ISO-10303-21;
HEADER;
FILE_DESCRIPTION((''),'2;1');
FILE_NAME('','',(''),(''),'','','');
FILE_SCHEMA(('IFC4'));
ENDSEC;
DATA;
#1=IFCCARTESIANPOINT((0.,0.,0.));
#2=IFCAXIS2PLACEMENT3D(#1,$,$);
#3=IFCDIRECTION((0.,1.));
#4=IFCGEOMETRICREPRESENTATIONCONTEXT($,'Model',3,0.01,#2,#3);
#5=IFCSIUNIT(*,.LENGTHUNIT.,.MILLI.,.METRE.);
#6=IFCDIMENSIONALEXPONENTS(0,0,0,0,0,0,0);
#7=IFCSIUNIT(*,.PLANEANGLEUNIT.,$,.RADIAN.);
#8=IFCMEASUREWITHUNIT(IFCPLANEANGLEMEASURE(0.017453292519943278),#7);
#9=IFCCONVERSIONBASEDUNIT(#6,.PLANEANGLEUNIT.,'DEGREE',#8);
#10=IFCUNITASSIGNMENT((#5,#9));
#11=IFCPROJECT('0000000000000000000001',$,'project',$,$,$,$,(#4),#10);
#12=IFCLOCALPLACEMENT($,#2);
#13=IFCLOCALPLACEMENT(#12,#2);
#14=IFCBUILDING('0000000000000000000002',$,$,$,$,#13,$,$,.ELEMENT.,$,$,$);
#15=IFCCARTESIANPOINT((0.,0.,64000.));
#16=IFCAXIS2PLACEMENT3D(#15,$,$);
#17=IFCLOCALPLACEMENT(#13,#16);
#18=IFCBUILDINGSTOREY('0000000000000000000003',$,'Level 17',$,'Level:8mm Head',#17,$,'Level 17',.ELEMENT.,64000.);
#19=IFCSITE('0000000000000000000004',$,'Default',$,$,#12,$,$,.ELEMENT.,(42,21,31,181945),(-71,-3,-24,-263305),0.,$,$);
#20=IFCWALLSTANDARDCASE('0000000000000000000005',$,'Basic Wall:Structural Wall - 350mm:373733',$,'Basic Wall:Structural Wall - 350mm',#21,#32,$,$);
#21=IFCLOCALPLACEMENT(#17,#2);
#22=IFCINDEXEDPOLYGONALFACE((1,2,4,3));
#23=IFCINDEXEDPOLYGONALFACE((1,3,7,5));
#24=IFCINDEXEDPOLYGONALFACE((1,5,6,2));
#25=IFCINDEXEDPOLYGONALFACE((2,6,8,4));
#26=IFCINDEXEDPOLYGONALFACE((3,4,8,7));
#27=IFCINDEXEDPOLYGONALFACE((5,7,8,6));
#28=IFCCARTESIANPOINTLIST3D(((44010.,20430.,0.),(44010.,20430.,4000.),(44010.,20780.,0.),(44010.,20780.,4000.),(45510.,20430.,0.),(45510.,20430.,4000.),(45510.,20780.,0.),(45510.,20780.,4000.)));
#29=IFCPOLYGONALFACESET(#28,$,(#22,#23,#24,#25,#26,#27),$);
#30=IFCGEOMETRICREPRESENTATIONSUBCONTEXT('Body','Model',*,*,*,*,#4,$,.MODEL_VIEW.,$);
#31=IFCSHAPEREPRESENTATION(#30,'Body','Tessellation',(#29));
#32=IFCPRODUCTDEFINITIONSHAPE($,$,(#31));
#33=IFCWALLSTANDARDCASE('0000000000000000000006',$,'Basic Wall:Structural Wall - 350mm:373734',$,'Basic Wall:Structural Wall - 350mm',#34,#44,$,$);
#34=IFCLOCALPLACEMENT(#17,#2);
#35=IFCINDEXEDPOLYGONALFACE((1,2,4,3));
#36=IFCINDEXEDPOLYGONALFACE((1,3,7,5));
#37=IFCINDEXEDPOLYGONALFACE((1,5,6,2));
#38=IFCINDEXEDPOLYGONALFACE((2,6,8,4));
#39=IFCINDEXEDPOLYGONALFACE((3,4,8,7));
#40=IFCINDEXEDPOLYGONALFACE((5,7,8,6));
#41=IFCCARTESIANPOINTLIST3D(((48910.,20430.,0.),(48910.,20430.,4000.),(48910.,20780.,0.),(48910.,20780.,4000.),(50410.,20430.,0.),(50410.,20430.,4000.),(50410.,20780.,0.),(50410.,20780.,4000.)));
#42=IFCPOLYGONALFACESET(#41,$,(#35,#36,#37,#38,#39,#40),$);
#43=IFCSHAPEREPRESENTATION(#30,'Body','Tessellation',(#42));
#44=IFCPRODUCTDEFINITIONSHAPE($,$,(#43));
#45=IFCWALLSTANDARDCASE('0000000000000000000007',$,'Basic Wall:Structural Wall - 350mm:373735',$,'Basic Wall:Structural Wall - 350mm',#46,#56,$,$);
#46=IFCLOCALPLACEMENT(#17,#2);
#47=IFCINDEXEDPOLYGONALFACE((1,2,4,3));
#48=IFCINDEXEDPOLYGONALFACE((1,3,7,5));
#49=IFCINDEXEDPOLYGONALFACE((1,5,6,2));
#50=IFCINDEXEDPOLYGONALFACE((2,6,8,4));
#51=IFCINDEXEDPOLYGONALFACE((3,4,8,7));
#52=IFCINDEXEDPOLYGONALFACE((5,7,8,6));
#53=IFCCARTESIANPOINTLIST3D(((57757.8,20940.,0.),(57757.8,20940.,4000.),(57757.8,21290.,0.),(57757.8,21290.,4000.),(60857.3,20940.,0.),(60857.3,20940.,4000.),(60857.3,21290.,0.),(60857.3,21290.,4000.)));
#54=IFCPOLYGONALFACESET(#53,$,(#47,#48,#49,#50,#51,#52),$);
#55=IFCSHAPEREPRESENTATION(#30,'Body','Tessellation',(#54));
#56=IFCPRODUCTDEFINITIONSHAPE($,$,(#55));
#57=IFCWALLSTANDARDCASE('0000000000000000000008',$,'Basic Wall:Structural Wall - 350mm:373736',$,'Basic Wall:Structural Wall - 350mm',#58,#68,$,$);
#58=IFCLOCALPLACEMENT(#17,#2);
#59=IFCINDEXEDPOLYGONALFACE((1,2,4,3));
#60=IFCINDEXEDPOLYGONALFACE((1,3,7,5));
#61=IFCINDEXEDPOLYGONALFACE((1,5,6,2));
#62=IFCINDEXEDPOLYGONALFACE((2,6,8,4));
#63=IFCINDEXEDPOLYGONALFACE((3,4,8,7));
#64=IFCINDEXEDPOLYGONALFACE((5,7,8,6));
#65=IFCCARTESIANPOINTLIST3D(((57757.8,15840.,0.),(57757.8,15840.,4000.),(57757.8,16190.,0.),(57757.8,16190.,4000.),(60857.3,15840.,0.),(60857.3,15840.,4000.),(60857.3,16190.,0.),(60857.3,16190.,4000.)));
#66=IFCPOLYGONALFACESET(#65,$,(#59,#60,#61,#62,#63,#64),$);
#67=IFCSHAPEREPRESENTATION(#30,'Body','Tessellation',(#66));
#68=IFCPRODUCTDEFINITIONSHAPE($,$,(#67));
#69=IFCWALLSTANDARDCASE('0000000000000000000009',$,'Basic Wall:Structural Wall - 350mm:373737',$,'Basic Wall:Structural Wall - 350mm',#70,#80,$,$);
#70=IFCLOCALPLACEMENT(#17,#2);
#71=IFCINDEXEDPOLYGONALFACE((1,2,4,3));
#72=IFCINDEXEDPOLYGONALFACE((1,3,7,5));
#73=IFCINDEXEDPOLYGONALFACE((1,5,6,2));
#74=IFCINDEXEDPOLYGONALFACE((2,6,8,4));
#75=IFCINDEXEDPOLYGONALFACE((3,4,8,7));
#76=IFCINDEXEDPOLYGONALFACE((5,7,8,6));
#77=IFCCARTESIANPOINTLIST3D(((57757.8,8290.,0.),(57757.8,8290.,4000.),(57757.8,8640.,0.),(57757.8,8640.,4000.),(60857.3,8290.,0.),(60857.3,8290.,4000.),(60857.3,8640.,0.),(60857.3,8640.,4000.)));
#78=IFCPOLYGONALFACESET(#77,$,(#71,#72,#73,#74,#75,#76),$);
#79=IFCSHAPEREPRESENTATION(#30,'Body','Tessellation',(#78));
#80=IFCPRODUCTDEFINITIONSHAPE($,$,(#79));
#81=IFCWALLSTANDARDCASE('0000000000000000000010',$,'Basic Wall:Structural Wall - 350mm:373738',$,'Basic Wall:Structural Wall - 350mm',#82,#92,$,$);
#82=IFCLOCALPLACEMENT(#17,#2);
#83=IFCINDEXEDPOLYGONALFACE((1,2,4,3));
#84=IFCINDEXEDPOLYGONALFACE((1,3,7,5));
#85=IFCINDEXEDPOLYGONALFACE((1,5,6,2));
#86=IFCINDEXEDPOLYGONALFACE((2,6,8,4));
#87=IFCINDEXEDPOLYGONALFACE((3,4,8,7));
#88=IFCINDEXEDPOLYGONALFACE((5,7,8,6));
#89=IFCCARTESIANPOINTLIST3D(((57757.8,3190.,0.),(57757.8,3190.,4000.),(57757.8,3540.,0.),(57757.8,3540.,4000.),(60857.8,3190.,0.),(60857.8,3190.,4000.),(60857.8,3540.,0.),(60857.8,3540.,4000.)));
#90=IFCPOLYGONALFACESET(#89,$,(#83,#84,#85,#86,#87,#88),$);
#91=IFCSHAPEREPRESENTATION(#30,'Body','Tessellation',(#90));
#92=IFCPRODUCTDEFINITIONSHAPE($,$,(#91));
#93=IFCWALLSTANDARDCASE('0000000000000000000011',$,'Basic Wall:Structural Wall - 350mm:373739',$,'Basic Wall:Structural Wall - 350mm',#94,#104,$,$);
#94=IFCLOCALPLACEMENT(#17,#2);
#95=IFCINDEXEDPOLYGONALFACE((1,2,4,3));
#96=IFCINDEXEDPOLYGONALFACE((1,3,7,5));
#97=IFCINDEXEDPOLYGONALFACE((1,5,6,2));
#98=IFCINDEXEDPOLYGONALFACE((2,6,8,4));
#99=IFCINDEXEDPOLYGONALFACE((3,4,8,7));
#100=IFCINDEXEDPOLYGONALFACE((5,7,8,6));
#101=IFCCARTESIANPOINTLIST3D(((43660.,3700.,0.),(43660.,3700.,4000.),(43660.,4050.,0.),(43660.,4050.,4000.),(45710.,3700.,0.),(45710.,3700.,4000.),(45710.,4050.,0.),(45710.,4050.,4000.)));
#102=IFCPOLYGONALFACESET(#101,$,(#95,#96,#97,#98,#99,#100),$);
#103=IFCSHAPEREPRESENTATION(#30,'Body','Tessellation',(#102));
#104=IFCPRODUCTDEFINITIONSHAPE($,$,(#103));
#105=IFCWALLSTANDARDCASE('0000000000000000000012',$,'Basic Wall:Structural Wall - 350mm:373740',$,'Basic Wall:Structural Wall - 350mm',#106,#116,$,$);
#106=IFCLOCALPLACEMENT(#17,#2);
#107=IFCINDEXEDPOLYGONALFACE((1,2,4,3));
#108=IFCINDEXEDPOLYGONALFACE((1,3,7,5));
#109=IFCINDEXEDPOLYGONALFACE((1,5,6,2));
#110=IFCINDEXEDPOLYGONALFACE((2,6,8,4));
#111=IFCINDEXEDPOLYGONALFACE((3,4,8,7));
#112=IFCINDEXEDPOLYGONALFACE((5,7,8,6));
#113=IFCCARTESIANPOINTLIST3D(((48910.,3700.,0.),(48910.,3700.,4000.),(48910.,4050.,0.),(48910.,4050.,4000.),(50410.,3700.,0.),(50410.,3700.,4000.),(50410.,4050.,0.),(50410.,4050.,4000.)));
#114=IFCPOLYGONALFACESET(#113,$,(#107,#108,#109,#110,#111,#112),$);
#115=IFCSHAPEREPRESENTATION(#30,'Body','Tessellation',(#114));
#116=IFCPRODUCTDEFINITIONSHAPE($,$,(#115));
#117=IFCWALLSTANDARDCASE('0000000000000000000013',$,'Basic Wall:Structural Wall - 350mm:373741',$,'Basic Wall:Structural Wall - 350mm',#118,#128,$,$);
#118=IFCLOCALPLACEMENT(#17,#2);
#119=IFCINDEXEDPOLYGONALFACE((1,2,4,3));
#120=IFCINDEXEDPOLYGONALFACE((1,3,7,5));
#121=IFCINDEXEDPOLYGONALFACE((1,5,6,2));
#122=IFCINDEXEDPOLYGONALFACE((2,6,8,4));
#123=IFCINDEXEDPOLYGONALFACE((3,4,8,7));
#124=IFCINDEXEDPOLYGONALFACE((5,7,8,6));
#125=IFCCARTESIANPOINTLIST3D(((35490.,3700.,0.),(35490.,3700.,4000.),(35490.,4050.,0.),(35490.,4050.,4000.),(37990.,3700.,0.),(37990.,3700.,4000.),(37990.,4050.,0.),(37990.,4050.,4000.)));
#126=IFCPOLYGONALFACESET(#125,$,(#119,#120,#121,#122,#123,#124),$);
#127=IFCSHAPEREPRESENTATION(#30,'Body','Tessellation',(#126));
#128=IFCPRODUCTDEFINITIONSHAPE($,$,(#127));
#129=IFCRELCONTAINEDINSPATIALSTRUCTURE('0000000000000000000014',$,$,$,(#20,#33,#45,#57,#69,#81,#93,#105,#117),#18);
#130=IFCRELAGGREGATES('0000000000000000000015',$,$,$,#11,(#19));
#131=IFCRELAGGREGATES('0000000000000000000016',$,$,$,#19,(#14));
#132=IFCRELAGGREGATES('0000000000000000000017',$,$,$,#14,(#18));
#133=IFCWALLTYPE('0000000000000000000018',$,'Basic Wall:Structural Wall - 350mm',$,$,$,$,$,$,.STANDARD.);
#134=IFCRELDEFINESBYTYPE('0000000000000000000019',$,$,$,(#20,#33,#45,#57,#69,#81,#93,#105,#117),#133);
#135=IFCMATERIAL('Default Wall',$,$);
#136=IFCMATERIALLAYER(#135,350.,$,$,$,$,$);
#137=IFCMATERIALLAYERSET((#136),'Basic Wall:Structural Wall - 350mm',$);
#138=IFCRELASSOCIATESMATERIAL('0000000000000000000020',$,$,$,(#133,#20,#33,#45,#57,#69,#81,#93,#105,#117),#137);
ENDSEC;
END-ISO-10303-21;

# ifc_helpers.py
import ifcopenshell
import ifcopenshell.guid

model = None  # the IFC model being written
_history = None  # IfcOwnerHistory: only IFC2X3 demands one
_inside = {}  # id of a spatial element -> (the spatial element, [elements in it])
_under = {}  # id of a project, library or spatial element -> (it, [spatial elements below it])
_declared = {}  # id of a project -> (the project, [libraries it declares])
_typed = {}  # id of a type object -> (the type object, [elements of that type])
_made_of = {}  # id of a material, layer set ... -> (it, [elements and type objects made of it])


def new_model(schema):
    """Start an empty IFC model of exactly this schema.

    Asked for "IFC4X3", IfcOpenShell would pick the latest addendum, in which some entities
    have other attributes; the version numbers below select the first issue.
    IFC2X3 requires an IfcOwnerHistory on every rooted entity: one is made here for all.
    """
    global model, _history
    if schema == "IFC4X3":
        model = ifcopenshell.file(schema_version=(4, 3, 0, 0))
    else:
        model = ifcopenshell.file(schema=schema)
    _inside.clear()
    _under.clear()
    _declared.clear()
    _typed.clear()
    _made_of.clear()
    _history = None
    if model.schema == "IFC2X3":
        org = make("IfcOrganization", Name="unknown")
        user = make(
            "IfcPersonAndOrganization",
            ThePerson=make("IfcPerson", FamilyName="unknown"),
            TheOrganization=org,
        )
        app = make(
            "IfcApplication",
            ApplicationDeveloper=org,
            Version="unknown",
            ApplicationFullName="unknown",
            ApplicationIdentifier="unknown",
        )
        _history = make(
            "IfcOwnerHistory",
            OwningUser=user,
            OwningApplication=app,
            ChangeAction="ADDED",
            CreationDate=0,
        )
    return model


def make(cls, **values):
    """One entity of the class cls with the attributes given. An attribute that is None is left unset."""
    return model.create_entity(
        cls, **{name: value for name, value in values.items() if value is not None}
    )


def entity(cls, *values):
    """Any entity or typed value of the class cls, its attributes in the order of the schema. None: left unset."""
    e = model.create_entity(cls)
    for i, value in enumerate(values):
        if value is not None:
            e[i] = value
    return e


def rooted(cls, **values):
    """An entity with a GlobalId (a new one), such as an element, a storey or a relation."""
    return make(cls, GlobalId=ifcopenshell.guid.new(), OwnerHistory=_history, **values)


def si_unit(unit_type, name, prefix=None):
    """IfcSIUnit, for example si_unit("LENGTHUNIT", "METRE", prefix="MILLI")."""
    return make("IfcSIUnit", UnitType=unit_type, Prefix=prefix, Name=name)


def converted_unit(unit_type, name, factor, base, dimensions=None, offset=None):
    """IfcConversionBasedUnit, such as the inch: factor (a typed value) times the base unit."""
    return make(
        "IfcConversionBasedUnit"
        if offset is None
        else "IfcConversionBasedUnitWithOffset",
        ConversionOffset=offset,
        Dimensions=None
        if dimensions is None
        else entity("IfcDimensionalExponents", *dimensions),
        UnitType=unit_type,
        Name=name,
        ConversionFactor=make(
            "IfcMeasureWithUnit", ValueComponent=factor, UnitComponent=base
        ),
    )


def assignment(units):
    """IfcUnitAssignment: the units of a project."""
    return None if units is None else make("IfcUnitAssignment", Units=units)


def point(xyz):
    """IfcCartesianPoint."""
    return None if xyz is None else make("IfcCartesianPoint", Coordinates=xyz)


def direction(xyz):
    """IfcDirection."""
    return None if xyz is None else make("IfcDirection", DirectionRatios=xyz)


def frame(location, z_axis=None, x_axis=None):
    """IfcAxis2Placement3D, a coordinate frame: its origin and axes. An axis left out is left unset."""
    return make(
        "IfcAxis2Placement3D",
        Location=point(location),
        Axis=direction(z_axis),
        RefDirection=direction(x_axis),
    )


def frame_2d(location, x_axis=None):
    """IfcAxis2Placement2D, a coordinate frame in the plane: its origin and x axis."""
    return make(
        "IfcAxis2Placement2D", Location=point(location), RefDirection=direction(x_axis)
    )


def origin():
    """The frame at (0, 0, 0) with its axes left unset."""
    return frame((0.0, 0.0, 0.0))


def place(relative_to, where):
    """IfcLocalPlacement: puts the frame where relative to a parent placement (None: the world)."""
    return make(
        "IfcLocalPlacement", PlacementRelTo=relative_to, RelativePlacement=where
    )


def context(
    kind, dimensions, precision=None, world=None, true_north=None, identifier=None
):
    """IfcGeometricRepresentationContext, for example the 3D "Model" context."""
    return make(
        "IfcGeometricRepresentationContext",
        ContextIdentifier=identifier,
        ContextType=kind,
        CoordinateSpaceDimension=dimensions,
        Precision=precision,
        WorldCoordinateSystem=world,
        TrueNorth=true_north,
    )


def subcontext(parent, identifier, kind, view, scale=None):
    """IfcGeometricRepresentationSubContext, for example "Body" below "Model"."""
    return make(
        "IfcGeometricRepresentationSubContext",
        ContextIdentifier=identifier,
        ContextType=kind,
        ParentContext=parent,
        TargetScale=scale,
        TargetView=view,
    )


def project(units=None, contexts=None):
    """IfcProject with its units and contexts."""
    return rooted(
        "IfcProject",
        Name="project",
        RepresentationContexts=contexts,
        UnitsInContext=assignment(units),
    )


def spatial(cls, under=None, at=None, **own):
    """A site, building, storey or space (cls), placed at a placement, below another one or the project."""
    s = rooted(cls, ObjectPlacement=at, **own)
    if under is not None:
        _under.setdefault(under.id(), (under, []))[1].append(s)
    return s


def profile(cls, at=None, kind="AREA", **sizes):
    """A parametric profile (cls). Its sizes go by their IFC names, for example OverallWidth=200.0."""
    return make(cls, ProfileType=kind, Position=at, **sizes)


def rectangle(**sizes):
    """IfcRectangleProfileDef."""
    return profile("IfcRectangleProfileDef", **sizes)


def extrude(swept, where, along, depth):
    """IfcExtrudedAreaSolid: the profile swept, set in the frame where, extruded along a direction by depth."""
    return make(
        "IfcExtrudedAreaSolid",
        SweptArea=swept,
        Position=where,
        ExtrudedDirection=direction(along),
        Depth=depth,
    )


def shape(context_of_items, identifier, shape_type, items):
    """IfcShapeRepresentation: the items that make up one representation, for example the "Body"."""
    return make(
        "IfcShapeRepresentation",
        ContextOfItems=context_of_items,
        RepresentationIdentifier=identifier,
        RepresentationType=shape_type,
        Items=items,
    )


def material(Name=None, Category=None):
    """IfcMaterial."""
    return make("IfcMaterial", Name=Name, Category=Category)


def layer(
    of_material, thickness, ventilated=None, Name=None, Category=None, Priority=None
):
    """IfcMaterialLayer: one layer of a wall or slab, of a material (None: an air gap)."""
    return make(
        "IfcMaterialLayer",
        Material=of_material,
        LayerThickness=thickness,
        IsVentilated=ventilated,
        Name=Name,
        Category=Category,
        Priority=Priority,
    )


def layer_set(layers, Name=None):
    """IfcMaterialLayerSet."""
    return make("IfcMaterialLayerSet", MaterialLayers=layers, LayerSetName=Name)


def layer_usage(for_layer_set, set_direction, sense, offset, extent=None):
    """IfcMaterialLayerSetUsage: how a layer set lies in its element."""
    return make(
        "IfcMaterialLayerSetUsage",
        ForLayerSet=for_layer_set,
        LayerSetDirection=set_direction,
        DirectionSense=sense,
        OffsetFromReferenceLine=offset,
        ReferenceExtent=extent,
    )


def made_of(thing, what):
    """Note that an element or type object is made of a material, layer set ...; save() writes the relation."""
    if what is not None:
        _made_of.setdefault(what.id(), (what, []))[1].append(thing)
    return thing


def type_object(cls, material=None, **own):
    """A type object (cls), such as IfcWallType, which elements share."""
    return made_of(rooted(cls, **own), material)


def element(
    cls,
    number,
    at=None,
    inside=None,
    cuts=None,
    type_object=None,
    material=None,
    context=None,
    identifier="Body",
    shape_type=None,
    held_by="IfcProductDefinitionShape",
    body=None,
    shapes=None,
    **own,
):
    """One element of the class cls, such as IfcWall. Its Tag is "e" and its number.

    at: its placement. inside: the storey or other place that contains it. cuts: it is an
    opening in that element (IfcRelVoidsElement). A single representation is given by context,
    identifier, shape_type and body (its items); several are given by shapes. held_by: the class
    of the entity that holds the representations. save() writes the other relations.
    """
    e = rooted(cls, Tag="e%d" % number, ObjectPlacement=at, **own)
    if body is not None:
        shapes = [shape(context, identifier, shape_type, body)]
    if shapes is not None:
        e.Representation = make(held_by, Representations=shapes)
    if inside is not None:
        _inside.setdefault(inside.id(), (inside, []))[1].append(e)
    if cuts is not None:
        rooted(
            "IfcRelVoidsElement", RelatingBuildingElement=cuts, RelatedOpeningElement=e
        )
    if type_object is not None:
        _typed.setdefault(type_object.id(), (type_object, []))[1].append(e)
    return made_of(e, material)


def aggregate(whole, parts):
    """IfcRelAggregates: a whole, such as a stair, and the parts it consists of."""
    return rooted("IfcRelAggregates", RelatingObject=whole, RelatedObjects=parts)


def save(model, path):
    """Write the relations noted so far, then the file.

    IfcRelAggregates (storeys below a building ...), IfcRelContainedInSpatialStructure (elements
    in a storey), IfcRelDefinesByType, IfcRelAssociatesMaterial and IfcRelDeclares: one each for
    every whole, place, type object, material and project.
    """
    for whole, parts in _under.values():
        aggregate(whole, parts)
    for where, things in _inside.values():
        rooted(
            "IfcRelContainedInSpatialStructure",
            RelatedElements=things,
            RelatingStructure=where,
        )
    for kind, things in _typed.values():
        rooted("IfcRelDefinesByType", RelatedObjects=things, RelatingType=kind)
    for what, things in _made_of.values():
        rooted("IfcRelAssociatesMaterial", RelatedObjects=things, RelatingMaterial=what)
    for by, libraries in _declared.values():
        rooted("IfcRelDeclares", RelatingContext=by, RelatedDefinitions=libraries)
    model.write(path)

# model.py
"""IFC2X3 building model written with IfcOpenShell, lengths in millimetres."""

from ifc_helpers import new_model, entity, si_unit, converted_unit, direction, frame, frame_2d, origin, place, context, subcontext, project, spatial, rectangle, extrude, material, layer, layer_set, layer_usage, type_object, element, save


model = new_model("IFC2X3")

# Units and contexts
model_context = context("Model", 3, precision=0.01, world=origin(), true_north=direction((0.0, 1.0)))
body_context = subcontext(model_context, "Body", "Model", "MODEL_VIEW")
ifc_project = project(units=[si_unit("LENGTHUNIT", "METRE", prefix="MILLI"), converted_unit("PLANEANGLEUNIT", "DEGREE", entity("IfcPlaneAngleMeasure", 0.017453292519943278), si_unit("PLANEANGLEUNIT", "RADIAN"), dimensions=[0, 0, 0, 0, 0, 0, 0])], contexts=[model_context])

# Site, building, storey
site_placement = place(None, origin())
site = spatial("IfcSite", under=ifc_project, at=site_placement, Name="Default", CompositionType="ELEMENT", RefLatitude=(42, 21, 31, 181945), RefLongitude=(-71, -3, -24, -263305), RefElevation=0.0)
building_placement = place(site_placement, origin())
building = spatial("IfcBuilding", under=site, at=building_placement, CompositionType="ELEMENT")
storey_placement = place(building_placement, frame((0.0, 0.0, 64000.0)))
storey = spatial("IfcBuildingStorey", under=building, at=storey_placement, Name="Level 17", ObjectType="Level:8mm Head", LongName="Level 17", CompositionType="ELEMENT", Elevation=64000.0)

# Walls
ifc_material_1 = material(Name="Default Wall")
ifc_layer_1 = layer(ifc_material_1, 350.0)
ifc_layer_set_1 = layer_set([ifc_layer_1], Name="Basic Wall:Structural Wall - 350mm")
wall_type_1 = type_object("IfcWallType", Name="Basic Wall:Structural Wall - 350mm", PredefinedType="STANDARD", material=ifc_layer_set_1)
ifc_layer_usage_1 = layer_usage(ifc_layer_set_1, "AXIS2", "NEGATIVE", 175.0)
wall_1_placement = place(storey_placement, frame((44010.0, 20605.0, 0.0)))
element("IfcWallStandardCase", 1, at=wall_1_placement, inside=storey, type_object=wall_type_1, material=ifc_layer_usage_1, Name="Basic Wall:Structural Wall - 350mm:373733", ObjectType="Basic Wall:Structural Wall - 350mm", context=body_context, shape_type="SweptSolid", body=[
    extrude(rectangle(XDim=1500.0, YDim=350.0, at=frame_2d((750.0, 0.0), x_axis=(-1.0, 0.0))), origin(), (0.0, 0.0, 1.0), 4000.0),
])
ifc_layer_usage_2 = layer_usage(ifc_layer_set_1, "AXIS2", "NEGATIVE", 175.0)
wall_2_placement = place(storey_placement, frame((48910.0, 20605.0, 0.0)))
element("IfcWallStandardCase", 2, at=wall_2_placement, inside=storey, type_object=wall_type_1, material=ifc_layer_usage_2, Name="Basic Wall:Structural Wall - 350mm:373734", ObjectType="Basic Wall:Structural Wall - 350mm", context=body_context, shape_type="SweptSolid", body=[
    extrude(rectangle(XDim=1500.0, YDim=350.0, at=frame_2d((750.0, 0.0), x_axis=(-1.0, 0.0))), origin(), (0.0, 0.0, 1.0), 4000.0),
])
ifc_layer_usage_3 = layer_usage(ifc_layer_set_1, "AXIS2", "NEGATIVE", 175.0)
wall_3_placement = place(storey_placement, frame((57757.8, 21115.0, 0.0)))
element("IfcWallStandardCase", 3, at=wall_3_placement, inside=storey, type_object=wall_type_1, material=ifc_layer_usage_3, Name="Basic Wall:Structural Wall - 350mm:373735", ObjectType="Basic Wall:Structural Wall - 350mm", context=body_context, shape_type="SweptSolid", body=[
    extrude(rectangle(XDim=3099.5, YDim=350.0, at=frame_2d((1549.8, 0.0), x_axis=(-1.0, 0.0))), origin(), (0.0, 0.0, 1.0), 4000.0),
])
ifc_layer_usage_4 = layer_usage(ifc_layer_set_1, "AXIS2", "NEGATIVE", 175.0)
wall_4_placement = place(storey_placement, frame((57757.8, 16015.0, 0.0)))
element("IfcWallStandardCase", 4, at=wall_4_placement, inside=storey, type_object=wall_type_1, material=ifc_layer_usage_4, Name="Basic Wall:Structural Wall - 350mm:373736", ObjectType="Basic Wall:Structural Wall - 350mm", context=body_context, shape_type="SweptSolid", body=[
    extrude(rectangle(XDim=3099.5, YDim=350.0, at=frame_2d((1549.8, 0.0), x_axis=(-1.0, 0.0))), origin(), (0.0, 0.0, 1.0), 4000.0),
])
ifc_layer_usage_5 = layer_usage(ifc_layer_set_1, "AXIS2", "POSITIVE", -175.0)
wall_5_placement = place(storey_placement, frame((57757.8, 8465.0, 0.0)))
element("IfcWallStandardCase", 5, at=wall_5_placement, inside=storey, type_object=wall_type_1, material=ifc_layer_usage_5, Name="Basic Wall:Structural Wall - 350mm:373737", ObjectType="Basic Wall:Structural Wall - 350mm", context=body_context, shape_type="SweptSolid", body=[
    extrude(rectangle(XDim=3099.5, YDim=350.0, at=frame_2d((1549.8, 0.0), x_axis=(-1.0, 0.0))), origin(), (0.0, 0.0, 1.0), 4000.0),
])
ifc_layer_usage_6 = layer_usage(ifc_layer_set_1, "AXIS2", "POSITIVE", -175.0)
wall_6_placement = place(storey_placement, frame((57757.8, 3365.0, 0.0)))
element("IfcWallStandardCase", 6, at=wall_6_placement, inside=storey, type_object=wall_type_1, material=ifc_layer_usage_6, Name="Basic Wall:Structural Wall - 350mm:373738", ObjectType="Basic Wall:Structural Wall - 350mm", context=body_context, shape_type="SweptSolid", body=[
    extrude(rectangle(XDim=3100.0, YDim=350.0, at=frame_2d((1550.0, 0.0), x_axis=(-1.0, 0.0))), origin(), (0.0, 0.0, 1.0), 4000.0),
])
ifc_layer_usage_7 = layer_usage(ifc_layer_set_1, "AXIS2", "POSITIVE", -175.0)
wall_7_placement = place(storey_placement, frame((43660.0, 3875.0, 0.0)))
element("IfcWallStandardCase", 7, at=wall_7_placement, inside=storey, type_object=wall_type_1, material=ifc_layer_usage_7, Name="Basic Wall:Structural Wall - 350mm:373739", ObjectType="Basic Wall:Structural Wall - 350mm", context=body_context, shape_type="SweptSolid", body=[
    extrude(rectangle(XDim=2050.0, YDim=350.0, at=frame_2d((1025.0, 0.0), x_axis=(-1.0, 0.0))), origin(), (0.0, 0.0, 1.0), 4000.0),
])
ifc_layer_usage_8 = layer_usage(ifc_layer_set_1, "AXIS2", "POSITIVE", -175.0)
wall_8_placement = place(storey_placement, frame((48910.0, 3875.0, 0.0)))
element("IfcWallStandardCase", 8, at=wall_8_placement, inside=storey, type_object=wall_type_1, material=ifc_layer_usage_8, Name="Basic Wall:Structural Wall - 350mm:373740", ObjectType="Basic Wall:Structural Wall - 350mm", context=body_context, shape_type="SweptSolid", body=[
    extrude(rectangle(XDim=1500.0, YDim=350.0, at=frame_2d((750.0, 0.0), x_axis=(-1.0, 0.0))), origin(), (0.0, 0.0, 1.0), 4000.0),
])
ifc_layer_usage_9 = layer_usage(ifc_layer_set_1, "AXIS2", "POSITIVE", -175.0)
wall_9_placement = place(storey_placement, frame((35490.0, 3875.0, 0.0)))
element("IfcWallStandardCase", 9, at=wall_9_placement, inside=storey, type_object=wall_type_1, material=ifc_layer_usage_9, Name="Basic Wall:Structural Wall - 350mm:373741", ObjectType="Basic Wall:Structural Wall - 350mm", context=body_context, shape_type="SweptSolid", body=[
    extrude(rectangle(XDim=2500.0, YDim=350.0, at=frame_2d((1250.0, 0.0), x_axis=(-1.0, 0.0))), origin(), (0.0, 0.0, 1.0), 4000.0),
])

save(model, "model.ifc")
